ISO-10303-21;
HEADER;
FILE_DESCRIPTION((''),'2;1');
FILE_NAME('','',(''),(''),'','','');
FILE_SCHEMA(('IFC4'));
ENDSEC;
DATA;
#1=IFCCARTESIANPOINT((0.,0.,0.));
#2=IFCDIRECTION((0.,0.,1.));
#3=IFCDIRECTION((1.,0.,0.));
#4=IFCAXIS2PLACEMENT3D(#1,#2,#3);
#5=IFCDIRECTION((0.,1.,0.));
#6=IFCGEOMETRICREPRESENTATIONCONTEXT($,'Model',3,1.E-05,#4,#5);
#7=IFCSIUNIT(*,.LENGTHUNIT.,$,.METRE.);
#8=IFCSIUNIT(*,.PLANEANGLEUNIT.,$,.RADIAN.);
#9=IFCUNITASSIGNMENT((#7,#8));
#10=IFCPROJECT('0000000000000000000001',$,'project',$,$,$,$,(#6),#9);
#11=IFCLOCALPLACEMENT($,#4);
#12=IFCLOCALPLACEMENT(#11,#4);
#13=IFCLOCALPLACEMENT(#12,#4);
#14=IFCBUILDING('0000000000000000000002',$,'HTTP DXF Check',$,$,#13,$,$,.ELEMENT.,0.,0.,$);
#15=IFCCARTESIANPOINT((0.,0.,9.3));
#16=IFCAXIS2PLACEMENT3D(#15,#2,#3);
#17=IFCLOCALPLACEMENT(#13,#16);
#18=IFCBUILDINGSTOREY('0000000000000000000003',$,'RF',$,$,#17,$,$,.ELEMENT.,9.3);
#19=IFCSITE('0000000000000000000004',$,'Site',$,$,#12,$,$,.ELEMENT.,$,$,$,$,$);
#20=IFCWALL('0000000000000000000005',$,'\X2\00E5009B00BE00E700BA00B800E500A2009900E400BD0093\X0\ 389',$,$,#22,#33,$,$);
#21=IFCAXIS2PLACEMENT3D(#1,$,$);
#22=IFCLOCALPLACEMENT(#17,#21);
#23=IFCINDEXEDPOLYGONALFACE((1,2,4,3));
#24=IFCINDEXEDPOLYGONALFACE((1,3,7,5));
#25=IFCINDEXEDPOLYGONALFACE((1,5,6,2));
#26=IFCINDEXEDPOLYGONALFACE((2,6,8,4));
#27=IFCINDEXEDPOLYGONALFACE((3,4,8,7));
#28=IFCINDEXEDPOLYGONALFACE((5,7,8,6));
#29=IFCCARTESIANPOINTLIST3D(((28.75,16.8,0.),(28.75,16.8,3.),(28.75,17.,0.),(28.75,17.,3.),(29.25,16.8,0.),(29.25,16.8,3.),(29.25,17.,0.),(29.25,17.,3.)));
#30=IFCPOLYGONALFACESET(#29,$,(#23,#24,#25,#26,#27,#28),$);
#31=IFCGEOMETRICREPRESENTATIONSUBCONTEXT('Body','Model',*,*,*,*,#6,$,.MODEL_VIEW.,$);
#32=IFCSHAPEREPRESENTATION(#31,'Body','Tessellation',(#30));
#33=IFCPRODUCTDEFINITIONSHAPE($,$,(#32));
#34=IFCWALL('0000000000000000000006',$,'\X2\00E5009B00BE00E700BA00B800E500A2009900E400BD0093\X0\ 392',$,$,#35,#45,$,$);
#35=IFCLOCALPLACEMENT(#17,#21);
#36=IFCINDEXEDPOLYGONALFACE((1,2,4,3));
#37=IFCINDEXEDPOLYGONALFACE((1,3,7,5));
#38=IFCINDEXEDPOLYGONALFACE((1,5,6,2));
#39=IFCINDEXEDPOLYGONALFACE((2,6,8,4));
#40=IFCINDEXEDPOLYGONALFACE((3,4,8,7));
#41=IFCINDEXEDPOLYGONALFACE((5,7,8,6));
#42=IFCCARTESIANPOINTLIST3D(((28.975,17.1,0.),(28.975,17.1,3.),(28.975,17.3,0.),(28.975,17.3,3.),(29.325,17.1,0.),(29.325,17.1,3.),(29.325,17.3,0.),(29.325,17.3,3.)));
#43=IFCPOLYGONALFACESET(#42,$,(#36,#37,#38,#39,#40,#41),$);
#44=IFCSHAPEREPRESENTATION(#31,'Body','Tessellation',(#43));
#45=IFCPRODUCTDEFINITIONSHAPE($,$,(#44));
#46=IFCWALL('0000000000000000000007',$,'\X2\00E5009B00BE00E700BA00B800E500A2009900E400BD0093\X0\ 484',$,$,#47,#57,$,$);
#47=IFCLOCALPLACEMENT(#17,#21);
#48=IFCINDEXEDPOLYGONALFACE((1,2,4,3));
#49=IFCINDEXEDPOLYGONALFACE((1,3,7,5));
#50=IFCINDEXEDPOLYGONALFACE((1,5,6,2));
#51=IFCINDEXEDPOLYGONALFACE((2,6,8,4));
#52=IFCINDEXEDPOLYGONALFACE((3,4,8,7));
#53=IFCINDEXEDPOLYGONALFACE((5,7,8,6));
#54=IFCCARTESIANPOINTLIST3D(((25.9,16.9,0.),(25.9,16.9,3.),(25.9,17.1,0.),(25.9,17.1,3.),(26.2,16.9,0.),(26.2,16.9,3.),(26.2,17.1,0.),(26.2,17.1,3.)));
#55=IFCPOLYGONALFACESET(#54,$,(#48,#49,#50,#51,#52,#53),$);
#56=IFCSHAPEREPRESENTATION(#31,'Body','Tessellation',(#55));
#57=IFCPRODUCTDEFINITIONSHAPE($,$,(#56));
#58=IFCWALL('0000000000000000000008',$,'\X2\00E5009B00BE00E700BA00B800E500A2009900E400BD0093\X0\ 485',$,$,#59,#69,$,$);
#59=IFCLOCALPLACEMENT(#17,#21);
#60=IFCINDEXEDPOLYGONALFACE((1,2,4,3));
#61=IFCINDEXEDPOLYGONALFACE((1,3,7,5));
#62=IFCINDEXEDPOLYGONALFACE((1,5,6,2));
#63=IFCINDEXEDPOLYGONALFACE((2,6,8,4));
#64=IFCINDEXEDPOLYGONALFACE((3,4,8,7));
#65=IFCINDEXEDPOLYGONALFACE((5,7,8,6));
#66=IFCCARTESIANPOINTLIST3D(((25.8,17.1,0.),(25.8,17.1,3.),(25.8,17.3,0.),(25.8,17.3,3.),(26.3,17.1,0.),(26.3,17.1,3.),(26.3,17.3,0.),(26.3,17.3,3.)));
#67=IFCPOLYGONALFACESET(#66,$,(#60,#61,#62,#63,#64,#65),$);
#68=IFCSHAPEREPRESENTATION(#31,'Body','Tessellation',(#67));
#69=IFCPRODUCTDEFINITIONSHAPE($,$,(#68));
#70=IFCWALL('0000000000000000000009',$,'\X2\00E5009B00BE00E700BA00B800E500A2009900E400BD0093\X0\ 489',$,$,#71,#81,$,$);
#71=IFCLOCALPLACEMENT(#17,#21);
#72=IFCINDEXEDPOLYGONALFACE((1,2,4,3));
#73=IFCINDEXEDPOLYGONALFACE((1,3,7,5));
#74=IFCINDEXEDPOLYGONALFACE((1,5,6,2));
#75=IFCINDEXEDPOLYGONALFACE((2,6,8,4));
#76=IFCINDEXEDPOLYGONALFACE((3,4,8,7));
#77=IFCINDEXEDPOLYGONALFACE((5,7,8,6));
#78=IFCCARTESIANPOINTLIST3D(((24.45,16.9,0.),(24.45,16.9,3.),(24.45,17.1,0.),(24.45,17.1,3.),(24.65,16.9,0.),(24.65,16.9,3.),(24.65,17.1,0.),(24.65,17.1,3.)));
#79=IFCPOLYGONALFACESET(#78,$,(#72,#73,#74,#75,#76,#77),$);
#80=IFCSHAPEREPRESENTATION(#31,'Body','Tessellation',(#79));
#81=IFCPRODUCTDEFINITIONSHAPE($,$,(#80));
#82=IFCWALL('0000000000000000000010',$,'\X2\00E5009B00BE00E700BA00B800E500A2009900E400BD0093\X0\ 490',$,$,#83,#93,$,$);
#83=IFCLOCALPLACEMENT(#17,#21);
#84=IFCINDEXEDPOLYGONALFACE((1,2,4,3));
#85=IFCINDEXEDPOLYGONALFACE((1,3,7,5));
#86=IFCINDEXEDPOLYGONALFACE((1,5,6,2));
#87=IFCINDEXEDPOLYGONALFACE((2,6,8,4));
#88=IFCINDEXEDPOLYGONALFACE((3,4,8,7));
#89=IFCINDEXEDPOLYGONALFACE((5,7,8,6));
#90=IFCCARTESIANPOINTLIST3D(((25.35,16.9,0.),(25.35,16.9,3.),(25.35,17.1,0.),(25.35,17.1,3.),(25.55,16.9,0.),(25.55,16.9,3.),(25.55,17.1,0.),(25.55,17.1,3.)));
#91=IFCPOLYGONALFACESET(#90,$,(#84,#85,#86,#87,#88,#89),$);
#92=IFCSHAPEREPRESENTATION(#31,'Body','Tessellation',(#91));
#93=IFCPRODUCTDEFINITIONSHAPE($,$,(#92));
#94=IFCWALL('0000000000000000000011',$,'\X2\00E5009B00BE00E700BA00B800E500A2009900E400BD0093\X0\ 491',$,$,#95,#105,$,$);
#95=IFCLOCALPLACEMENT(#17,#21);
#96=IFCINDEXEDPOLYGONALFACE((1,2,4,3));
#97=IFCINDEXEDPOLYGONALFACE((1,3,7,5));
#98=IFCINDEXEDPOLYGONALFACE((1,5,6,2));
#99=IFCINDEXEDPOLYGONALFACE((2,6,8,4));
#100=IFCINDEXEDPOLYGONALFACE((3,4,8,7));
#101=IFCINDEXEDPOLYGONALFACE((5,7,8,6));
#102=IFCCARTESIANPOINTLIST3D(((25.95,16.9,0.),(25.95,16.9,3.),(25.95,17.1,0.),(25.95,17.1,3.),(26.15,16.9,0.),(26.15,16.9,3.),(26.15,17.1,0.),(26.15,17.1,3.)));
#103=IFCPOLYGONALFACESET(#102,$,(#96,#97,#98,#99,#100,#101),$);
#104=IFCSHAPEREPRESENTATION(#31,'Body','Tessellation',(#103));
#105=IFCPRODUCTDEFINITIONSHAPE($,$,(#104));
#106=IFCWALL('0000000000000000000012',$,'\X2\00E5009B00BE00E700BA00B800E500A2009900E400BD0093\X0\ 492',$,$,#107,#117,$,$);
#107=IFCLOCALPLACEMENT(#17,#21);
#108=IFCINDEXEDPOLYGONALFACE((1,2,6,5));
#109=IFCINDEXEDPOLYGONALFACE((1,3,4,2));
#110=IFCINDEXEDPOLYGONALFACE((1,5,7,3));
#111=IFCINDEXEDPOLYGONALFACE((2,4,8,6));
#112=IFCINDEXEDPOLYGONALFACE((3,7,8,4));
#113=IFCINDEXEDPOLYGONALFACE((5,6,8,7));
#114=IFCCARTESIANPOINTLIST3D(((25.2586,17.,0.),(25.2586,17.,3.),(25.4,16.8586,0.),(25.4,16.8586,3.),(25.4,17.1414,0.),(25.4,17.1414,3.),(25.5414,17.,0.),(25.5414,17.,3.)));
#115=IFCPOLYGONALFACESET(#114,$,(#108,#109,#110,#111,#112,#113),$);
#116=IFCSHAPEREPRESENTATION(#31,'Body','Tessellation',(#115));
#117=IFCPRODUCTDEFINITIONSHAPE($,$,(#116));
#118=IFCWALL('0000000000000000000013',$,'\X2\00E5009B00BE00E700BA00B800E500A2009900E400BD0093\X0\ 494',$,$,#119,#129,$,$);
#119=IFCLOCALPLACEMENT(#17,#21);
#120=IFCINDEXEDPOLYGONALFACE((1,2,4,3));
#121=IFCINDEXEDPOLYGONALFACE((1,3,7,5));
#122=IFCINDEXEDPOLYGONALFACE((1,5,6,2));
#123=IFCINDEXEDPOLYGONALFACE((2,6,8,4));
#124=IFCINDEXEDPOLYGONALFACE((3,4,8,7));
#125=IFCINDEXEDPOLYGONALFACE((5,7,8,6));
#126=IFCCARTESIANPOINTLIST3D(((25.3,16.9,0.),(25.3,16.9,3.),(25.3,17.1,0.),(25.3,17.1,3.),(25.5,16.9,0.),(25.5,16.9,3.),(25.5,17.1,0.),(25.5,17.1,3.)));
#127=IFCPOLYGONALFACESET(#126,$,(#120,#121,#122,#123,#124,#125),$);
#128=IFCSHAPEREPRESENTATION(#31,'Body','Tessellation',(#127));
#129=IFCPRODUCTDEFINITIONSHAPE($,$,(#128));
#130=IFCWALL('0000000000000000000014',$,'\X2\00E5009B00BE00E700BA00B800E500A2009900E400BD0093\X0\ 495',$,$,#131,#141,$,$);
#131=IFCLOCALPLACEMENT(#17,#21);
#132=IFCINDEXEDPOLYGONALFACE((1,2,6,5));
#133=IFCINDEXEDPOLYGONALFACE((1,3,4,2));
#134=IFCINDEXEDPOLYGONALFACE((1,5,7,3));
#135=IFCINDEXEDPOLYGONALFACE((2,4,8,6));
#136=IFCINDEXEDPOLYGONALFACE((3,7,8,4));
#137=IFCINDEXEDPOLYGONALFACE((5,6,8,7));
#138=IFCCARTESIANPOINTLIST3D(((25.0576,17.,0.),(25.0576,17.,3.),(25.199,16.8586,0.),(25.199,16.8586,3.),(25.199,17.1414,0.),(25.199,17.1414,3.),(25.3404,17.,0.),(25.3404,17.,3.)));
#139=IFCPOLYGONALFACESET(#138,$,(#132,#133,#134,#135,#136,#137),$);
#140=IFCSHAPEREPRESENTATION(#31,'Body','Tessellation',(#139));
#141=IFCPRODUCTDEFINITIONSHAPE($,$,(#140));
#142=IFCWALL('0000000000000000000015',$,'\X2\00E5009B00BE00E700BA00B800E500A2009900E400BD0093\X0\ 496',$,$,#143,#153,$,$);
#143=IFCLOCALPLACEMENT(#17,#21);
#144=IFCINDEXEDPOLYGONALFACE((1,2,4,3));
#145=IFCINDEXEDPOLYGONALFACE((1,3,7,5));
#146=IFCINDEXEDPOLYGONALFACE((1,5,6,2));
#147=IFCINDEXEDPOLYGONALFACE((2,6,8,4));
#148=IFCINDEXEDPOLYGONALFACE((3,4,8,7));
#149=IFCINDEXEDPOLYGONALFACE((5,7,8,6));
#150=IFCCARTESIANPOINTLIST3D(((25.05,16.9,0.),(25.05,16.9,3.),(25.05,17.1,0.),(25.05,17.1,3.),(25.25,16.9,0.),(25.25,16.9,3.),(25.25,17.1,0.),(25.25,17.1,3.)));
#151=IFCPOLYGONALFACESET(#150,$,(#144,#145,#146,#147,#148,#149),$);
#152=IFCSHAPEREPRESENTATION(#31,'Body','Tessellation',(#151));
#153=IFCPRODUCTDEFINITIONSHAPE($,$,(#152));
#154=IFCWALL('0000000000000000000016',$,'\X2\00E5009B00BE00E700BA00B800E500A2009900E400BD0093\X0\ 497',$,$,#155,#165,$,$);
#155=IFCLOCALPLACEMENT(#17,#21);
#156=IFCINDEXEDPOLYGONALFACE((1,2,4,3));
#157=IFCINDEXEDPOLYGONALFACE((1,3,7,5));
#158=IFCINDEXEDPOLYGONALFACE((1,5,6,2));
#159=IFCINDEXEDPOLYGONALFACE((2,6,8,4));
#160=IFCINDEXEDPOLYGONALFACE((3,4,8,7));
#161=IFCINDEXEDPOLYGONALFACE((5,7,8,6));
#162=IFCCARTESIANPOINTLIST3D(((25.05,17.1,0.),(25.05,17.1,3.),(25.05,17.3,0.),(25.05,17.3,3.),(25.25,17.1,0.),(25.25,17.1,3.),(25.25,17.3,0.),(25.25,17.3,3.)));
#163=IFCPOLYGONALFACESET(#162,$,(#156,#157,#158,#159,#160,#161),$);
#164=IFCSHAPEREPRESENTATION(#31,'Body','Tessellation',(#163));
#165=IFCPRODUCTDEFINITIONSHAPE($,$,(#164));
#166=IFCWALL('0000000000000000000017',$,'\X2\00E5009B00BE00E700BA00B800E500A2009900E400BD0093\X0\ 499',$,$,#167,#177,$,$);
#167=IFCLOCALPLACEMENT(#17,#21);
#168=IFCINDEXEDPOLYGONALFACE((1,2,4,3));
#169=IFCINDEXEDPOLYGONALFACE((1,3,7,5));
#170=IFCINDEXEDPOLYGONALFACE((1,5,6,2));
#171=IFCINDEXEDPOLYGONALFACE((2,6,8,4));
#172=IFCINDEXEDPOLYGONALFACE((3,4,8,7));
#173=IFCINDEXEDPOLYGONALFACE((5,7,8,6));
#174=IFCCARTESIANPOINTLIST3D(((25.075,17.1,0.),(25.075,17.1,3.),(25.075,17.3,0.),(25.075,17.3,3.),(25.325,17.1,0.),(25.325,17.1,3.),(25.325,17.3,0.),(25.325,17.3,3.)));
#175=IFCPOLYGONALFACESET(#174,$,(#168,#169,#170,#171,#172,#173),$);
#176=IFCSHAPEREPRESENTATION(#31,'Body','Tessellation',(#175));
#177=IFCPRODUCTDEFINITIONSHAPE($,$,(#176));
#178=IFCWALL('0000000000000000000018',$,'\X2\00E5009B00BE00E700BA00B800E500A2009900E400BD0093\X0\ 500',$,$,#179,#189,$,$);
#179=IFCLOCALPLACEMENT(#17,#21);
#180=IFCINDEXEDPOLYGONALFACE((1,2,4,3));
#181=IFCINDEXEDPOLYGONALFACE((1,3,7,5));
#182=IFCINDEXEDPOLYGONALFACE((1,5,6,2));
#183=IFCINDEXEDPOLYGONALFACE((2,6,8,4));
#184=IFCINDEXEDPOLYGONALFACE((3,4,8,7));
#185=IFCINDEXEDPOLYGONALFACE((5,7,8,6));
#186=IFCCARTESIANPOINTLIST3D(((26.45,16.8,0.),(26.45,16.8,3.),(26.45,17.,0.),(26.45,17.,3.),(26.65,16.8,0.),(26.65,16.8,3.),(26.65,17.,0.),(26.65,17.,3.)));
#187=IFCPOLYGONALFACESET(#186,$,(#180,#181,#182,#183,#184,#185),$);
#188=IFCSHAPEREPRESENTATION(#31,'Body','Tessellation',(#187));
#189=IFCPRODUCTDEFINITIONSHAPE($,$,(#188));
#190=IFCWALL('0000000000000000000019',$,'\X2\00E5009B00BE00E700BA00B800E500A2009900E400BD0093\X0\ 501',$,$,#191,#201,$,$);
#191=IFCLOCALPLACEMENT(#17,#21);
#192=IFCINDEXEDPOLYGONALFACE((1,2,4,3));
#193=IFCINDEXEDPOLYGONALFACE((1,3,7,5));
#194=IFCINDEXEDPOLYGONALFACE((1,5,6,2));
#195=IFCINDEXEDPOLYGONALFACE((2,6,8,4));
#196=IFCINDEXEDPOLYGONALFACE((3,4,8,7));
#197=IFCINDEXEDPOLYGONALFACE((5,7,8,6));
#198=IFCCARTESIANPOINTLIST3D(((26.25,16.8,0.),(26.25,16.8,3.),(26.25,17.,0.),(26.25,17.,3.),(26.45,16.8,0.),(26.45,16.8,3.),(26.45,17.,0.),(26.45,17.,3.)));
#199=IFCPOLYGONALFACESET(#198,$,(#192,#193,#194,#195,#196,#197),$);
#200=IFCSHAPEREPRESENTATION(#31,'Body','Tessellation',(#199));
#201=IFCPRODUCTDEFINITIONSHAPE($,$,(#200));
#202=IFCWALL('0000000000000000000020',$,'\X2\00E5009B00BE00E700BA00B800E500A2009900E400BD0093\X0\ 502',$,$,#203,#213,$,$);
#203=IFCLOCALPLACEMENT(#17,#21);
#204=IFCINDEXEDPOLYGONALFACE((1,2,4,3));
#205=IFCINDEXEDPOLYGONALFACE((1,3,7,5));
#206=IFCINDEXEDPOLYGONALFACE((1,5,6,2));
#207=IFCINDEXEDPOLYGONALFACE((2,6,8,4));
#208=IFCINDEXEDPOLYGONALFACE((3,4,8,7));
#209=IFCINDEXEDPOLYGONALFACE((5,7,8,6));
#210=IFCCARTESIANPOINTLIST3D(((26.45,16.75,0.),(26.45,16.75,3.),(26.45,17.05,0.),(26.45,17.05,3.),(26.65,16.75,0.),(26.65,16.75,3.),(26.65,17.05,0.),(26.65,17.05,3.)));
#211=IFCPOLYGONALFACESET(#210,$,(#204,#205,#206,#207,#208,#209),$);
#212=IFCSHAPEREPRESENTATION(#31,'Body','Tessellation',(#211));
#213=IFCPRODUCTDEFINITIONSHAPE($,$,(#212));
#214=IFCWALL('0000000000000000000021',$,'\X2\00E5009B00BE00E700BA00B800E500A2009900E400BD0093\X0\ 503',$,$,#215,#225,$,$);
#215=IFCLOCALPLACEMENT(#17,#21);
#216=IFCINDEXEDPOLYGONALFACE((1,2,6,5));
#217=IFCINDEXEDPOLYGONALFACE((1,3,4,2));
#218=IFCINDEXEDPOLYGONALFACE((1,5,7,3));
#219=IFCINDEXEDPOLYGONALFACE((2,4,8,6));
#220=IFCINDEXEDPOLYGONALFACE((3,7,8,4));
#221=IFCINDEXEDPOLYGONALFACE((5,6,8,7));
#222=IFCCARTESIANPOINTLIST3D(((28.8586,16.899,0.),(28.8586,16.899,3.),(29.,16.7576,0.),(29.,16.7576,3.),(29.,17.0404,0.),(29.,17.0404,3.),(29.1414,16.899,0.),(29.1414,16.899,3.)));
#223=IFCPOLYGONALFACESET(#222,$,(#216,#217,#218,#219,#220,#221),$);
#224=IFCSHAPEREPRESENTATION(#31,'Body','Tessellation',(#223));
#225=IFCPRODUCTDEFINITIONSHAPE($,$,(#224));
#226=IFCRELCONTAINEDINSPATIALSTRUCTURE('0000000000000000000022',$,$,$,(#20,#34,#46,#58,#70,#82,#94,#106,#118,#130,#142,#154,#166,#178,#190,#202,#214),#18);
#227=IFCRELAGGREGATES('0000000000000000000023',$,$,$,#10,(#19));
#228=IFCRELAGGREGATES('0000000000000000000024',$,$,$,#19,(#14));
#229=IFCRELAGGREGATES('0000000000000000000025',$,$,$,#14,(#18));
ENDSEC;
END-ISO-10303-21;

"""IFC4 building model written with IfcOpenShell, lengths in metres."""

from ifc_helpers import new_model, si_unit, direction, frame, frame_2d, origin_with_axes, place, context, subcontext, project, spatial, rectangle, extrude, element, save


model = new_model("IFC4")

# Units and contexts
model_context = context("Model", 3, precision=1e-05, world=origin_with_axes(), true_north=direction((0.0, 1.0, 0.0)))
body_context = subcontext(model_context, "Body", "Model", "MODEL_VIEW")
ifc_project = project(units=[si_unit("LENGTHUNIT", "METRE"), si_unit("PLANEANGLEUNIT", "RADIAN")], contexts=[model_context])

# Site, building, storey
placement = place(None, origin_with_axes())
site_placement = place(placement, origin_with_axes())
site = spatial("IfcSite", under=ifc_project, at=site_placement, Name="Site", CompositionType="ELEMENT")
building_placement = place(site_placement, origin_with_axes())
building = spatial("IfcBuilding", under=site, at=building_placement, Name="HTTP DXF Check", CompositionType="ELEMENT", ElevationOfRefHeight=0.0, ElevationOfTerrain=0.0)
storey_placement = place(building_placement, frame((0.0, 0.0, 9.3), z_axis=(0.0, 0.0, 1.0), x_axis=(1.0, 0.0, 0.0)))
storey = spatial("IfcBuildingStorey", under=building, at=storey_placement, Name="RF", CompositionType="ELEMENT", Elevation=9.3)

# Walls
wall_1_placement = place(storey_placement, frame((29.0, 16.9, 0.0), z_axis=(0.0, 0.0, 1.0), x_axis=(1.0, 0.0, 0.0)))
element("IfcWall", 1, at=wall_1_placement, inside=storey, Name="å\u009b¾çº¸å¢\u0099ä½\u0093 389", context=body_context, shape_type="SweptSolid", body=[
    extrude(rectangle(XDim=0.5, YDim=0.2, at=frame_2d((0.0, 0.0), x_axis=(1.0, 0.0, 0.0))), frame((0.0, 0.0, 0.0), z_axis=(0.0, 0.0, 1.0)), (0.0, 0.0, 1.0), 3.0),
])
wall_2_placement = place(storey_placement, frame((29.15, 17.2, 0.0), z_axis=(0.0, 0.0, 1.0), x_axis=(1.0, 0.0, 0.0)))
element("IfcWall", 2, at=wall_2_placement, inside=storey, Name="å\u009b¾çº¸å¢\u0099ä½\u0093 392", context=body_context, shape_type="SweptSolid", body=[
    extrude(rectangle(XDim=0.35, YDim=0.2, at=frame_2d((0.0, 0.0), x_axis=(1.0, 0.0, 0.0))), frame((0.0, 0.0, 0.0), z_axis=(0.0, 0.0, 1.0)), (0.0, 0.0, 1.0), 3.0),
])
wall_3_placement = place(storey_placement, frame((26.05, 17.0, 0.0), z_axis=(0.0, 0.0, 1.0), x_axis=(1.0, 0.0, 0.0)))
element("IfcWall", 3, at=wall_3_placement, inside=storey, Name="å\u009b¾çº¸å¢\u0099ä½\u0093 484", context=body_context, shape_type="SweptSolid", body=[
    extrude(rectangle(XDim=0.3, YDim=0.2, at=frame_2d((0.0, 0.0), x_axis=(1.0, 0.0, 0.0))), frame((0.0, 0.0, 0.0), z_axis=(0.0, 0.0, 1.0)), (0.0, 0.0, 1.0), 3.0),
])
wall_4_placement = place(storey_placement, frame((26.05, 17.2, 0.0), z_axis=(0.0, 0.0, 1.0), x_axis=(1.0, 0.0, 0.0)))
element("IfcWall", 4, at=wall_4_placement, inside=storey, Name="å\u009b¾çº¸å¢\u0099ä½\u0093 485", context=body_context, shape_type="SweptSolid", body=[
    extrude(rectangle(XDim=0.5, YDim=0.2, at=frame_2d((0.0, 0.0), x_axis=(1.0, 0.0, 0.0))), frame((0.0, 0.0, 0.0), z_axis=(0.0, 0.0, 1.0)), (0.0, 0.0, 1.0), 3.0),
])
for number, where, z_axis, x_axis, name in (
    (5, (24.55, 17.0, 0.0), (0.0, 0.0, 1.0), (0.0, 1.0, 0.0), "å\u009b¾çº¸å¢\u0099ä½\u0093 489"),
    (6, (25.45, 17.0, 0.0), (0.0, 0.0, 1.0), (0.0, 1.0, 0.0), "å\u009b¾çº¸å¢\u0099ä½\u0093 490"),
    (7, (26.05, 17.0, 0.0), (0.0, 0.0, 1.0), (0.0, 1.0, 0.0), "å\u009b¾çº¸å¢\u0099ä½\u0093 491"),
    (8, (25.4, 17.0, 0.0), (0.0, 0.0, 1.0), (-0.707107, -0.707107, 0.0), "å\u009b¾çº¸å¢\u0099ä½\u0093 492"),
    (9, (25.4, 17.0, 0.0), (0.0, 0.0, 1.0), (1.0, 0.0, 0.0), "å\u009b¾çº¸å¢\u0099ä½\u0093 494"),
    (10, (25.199, 17.0, 0.0), (0.0, 0.0, 1.0), (0.707107, -0.707107, 0.0), "å\u009b¾çº¸å¢\u0099ä½\u0093 495"),
    (11, (25.15, 17.0, 0.0), (0.0, 0.0, 1.0), (1.0, 0.0, 0.0), "å\u009b¾çº¸å¢\u0099ä½\u0093 496"),
    (12, (25.15, 17.2, 0.0), (0.0, 0.0, 1.0), (1.0, 0.0, 0.0), "å\u009b¾çº¸å¢\u0099ä½\u0093 497"),
):
    element("IfcWall", number, at=place(storey_placement, frame(where, z_axis=z_axis, x_axis=x_axis)), inside=storey, Name=name, context=body_context, shape_type="SweptSolid", body=[
        extrude(rectangle(XDim=0.2, YDim=0.2, at=frame_2d((0.0, 0.0), x_axis=(1.0, 0.0, 0.0))), frame((0.0, 0.0, 0.0), z_axis=(0.0, 0.0, 1.0)), (0.0, 0.0, 1.0), 3.0),
    ])
wall_5_placement = place(storey_placement, frame((25.2, 17.2, 0.0), z_axis=(0.0, 0.0, 1.0), x_axis=(1.0, 0.0, 0.0)))
element("IfcWall", 13, at=wall_5_placement, inside=storey, Name="å\u009b¾çº¸å¢\u0099ä½\u0093 499", context=body_context, shape_type="SweptSolid", body=[
    extrude(rectangle(XDim=0.25, YDim=0.2, at=frame_2d((0.0, 0.0), x_axis=(1.0, 0.0, 0.0))), frame((0.0, 0.0, 0.0), z_axis=(0.0, 0.0, 1.0)), (0.0, 0.0, 1.0), 3.0),
])
for number, where, z_axis, x_axis, name in (
    (14, (26.55, 16.9, 0.0), (0.0, 0.0, 1.0), (-1.0, 0.0, 0.0), "å\u009b¾çº¸å¢\u0099ä½\u0093 500"),
    (15, (26.35, 16.9, 0.0), (0.0, 0.0, 1.0), (0.0, 1.0, 0.0), "å\u009b¾çº¸å¢\u0099ä½\u0093 501"),
):
    element("IfcWall", number, at=place(storey_placement, frame(where, z_axis=z_axis, x_axis=x_axis)), inside=storey, Name=name, context=body_context, shape_type="SweptSolid", body=[
        extrude(rectangle(XDim=0.2, YDim=0.2, at=frame_2d((0.0, 0.0), x_axis=(1.0, 0.0, 0.0))), frame((0.0, 0.0, 0.0), z_axis=(0.0, 0.0, 1.0)), (0.0, 0.0, 1.0), 3.0),
    ])
wall_6_placement = place(storey_placement, frame((26.55, 16.9, 0.0), z_axis=(0.0, 0.0, 1.0), x_axis=(0.0, 1.0, 0.0)))
element("IfcWall", 16, at=wall_6_placement, inside=storey, Name="å\u009b¾çº¸å¢\u0099ä½\u0093 502", context=body_context, shape_type="SweptSolid", body=[
    extrude(rectangle(XDim=0.3, YDim=0.2, at=frame_2d((0.0, 0.0), x_axis=(1.0, 0.0, 0.0))), frame((0.0, 0.0, 0.0), z_axis=(0.0, 0.0, 1.0)), (0.0, 0.0, 1.0), 3.0),
])
for number, where, z_axis, x_axis, name in (
    (17, (29.0, 16.899, 0.0), (0.0, 0.0, 1.0), (0.707107, 0.707107, 0.0), "å\u009b¾çº¸å¢\u0099ä½\u0093 503"),
):
    element("IfcWall", number, at=place(storey_placement, frame(where, z_axis=z_axis, x_axis=x_axis)), inside=storey, Name=name, context=body_context, shape_type="SweptSolid", body=[
        extrude(rectangle(XDim=0.2, YDim=0.2, at=frame_2d((0.0, 0.0), x_axis=(1.0, 0.0, 0.0))), frame((0.0, 0.0, 0.0), z_axis=(0.0, 0.0, 1.0)), (0.0, 0.0, 1.0), 3.0),
    ])

save(model, "model.ifc")
